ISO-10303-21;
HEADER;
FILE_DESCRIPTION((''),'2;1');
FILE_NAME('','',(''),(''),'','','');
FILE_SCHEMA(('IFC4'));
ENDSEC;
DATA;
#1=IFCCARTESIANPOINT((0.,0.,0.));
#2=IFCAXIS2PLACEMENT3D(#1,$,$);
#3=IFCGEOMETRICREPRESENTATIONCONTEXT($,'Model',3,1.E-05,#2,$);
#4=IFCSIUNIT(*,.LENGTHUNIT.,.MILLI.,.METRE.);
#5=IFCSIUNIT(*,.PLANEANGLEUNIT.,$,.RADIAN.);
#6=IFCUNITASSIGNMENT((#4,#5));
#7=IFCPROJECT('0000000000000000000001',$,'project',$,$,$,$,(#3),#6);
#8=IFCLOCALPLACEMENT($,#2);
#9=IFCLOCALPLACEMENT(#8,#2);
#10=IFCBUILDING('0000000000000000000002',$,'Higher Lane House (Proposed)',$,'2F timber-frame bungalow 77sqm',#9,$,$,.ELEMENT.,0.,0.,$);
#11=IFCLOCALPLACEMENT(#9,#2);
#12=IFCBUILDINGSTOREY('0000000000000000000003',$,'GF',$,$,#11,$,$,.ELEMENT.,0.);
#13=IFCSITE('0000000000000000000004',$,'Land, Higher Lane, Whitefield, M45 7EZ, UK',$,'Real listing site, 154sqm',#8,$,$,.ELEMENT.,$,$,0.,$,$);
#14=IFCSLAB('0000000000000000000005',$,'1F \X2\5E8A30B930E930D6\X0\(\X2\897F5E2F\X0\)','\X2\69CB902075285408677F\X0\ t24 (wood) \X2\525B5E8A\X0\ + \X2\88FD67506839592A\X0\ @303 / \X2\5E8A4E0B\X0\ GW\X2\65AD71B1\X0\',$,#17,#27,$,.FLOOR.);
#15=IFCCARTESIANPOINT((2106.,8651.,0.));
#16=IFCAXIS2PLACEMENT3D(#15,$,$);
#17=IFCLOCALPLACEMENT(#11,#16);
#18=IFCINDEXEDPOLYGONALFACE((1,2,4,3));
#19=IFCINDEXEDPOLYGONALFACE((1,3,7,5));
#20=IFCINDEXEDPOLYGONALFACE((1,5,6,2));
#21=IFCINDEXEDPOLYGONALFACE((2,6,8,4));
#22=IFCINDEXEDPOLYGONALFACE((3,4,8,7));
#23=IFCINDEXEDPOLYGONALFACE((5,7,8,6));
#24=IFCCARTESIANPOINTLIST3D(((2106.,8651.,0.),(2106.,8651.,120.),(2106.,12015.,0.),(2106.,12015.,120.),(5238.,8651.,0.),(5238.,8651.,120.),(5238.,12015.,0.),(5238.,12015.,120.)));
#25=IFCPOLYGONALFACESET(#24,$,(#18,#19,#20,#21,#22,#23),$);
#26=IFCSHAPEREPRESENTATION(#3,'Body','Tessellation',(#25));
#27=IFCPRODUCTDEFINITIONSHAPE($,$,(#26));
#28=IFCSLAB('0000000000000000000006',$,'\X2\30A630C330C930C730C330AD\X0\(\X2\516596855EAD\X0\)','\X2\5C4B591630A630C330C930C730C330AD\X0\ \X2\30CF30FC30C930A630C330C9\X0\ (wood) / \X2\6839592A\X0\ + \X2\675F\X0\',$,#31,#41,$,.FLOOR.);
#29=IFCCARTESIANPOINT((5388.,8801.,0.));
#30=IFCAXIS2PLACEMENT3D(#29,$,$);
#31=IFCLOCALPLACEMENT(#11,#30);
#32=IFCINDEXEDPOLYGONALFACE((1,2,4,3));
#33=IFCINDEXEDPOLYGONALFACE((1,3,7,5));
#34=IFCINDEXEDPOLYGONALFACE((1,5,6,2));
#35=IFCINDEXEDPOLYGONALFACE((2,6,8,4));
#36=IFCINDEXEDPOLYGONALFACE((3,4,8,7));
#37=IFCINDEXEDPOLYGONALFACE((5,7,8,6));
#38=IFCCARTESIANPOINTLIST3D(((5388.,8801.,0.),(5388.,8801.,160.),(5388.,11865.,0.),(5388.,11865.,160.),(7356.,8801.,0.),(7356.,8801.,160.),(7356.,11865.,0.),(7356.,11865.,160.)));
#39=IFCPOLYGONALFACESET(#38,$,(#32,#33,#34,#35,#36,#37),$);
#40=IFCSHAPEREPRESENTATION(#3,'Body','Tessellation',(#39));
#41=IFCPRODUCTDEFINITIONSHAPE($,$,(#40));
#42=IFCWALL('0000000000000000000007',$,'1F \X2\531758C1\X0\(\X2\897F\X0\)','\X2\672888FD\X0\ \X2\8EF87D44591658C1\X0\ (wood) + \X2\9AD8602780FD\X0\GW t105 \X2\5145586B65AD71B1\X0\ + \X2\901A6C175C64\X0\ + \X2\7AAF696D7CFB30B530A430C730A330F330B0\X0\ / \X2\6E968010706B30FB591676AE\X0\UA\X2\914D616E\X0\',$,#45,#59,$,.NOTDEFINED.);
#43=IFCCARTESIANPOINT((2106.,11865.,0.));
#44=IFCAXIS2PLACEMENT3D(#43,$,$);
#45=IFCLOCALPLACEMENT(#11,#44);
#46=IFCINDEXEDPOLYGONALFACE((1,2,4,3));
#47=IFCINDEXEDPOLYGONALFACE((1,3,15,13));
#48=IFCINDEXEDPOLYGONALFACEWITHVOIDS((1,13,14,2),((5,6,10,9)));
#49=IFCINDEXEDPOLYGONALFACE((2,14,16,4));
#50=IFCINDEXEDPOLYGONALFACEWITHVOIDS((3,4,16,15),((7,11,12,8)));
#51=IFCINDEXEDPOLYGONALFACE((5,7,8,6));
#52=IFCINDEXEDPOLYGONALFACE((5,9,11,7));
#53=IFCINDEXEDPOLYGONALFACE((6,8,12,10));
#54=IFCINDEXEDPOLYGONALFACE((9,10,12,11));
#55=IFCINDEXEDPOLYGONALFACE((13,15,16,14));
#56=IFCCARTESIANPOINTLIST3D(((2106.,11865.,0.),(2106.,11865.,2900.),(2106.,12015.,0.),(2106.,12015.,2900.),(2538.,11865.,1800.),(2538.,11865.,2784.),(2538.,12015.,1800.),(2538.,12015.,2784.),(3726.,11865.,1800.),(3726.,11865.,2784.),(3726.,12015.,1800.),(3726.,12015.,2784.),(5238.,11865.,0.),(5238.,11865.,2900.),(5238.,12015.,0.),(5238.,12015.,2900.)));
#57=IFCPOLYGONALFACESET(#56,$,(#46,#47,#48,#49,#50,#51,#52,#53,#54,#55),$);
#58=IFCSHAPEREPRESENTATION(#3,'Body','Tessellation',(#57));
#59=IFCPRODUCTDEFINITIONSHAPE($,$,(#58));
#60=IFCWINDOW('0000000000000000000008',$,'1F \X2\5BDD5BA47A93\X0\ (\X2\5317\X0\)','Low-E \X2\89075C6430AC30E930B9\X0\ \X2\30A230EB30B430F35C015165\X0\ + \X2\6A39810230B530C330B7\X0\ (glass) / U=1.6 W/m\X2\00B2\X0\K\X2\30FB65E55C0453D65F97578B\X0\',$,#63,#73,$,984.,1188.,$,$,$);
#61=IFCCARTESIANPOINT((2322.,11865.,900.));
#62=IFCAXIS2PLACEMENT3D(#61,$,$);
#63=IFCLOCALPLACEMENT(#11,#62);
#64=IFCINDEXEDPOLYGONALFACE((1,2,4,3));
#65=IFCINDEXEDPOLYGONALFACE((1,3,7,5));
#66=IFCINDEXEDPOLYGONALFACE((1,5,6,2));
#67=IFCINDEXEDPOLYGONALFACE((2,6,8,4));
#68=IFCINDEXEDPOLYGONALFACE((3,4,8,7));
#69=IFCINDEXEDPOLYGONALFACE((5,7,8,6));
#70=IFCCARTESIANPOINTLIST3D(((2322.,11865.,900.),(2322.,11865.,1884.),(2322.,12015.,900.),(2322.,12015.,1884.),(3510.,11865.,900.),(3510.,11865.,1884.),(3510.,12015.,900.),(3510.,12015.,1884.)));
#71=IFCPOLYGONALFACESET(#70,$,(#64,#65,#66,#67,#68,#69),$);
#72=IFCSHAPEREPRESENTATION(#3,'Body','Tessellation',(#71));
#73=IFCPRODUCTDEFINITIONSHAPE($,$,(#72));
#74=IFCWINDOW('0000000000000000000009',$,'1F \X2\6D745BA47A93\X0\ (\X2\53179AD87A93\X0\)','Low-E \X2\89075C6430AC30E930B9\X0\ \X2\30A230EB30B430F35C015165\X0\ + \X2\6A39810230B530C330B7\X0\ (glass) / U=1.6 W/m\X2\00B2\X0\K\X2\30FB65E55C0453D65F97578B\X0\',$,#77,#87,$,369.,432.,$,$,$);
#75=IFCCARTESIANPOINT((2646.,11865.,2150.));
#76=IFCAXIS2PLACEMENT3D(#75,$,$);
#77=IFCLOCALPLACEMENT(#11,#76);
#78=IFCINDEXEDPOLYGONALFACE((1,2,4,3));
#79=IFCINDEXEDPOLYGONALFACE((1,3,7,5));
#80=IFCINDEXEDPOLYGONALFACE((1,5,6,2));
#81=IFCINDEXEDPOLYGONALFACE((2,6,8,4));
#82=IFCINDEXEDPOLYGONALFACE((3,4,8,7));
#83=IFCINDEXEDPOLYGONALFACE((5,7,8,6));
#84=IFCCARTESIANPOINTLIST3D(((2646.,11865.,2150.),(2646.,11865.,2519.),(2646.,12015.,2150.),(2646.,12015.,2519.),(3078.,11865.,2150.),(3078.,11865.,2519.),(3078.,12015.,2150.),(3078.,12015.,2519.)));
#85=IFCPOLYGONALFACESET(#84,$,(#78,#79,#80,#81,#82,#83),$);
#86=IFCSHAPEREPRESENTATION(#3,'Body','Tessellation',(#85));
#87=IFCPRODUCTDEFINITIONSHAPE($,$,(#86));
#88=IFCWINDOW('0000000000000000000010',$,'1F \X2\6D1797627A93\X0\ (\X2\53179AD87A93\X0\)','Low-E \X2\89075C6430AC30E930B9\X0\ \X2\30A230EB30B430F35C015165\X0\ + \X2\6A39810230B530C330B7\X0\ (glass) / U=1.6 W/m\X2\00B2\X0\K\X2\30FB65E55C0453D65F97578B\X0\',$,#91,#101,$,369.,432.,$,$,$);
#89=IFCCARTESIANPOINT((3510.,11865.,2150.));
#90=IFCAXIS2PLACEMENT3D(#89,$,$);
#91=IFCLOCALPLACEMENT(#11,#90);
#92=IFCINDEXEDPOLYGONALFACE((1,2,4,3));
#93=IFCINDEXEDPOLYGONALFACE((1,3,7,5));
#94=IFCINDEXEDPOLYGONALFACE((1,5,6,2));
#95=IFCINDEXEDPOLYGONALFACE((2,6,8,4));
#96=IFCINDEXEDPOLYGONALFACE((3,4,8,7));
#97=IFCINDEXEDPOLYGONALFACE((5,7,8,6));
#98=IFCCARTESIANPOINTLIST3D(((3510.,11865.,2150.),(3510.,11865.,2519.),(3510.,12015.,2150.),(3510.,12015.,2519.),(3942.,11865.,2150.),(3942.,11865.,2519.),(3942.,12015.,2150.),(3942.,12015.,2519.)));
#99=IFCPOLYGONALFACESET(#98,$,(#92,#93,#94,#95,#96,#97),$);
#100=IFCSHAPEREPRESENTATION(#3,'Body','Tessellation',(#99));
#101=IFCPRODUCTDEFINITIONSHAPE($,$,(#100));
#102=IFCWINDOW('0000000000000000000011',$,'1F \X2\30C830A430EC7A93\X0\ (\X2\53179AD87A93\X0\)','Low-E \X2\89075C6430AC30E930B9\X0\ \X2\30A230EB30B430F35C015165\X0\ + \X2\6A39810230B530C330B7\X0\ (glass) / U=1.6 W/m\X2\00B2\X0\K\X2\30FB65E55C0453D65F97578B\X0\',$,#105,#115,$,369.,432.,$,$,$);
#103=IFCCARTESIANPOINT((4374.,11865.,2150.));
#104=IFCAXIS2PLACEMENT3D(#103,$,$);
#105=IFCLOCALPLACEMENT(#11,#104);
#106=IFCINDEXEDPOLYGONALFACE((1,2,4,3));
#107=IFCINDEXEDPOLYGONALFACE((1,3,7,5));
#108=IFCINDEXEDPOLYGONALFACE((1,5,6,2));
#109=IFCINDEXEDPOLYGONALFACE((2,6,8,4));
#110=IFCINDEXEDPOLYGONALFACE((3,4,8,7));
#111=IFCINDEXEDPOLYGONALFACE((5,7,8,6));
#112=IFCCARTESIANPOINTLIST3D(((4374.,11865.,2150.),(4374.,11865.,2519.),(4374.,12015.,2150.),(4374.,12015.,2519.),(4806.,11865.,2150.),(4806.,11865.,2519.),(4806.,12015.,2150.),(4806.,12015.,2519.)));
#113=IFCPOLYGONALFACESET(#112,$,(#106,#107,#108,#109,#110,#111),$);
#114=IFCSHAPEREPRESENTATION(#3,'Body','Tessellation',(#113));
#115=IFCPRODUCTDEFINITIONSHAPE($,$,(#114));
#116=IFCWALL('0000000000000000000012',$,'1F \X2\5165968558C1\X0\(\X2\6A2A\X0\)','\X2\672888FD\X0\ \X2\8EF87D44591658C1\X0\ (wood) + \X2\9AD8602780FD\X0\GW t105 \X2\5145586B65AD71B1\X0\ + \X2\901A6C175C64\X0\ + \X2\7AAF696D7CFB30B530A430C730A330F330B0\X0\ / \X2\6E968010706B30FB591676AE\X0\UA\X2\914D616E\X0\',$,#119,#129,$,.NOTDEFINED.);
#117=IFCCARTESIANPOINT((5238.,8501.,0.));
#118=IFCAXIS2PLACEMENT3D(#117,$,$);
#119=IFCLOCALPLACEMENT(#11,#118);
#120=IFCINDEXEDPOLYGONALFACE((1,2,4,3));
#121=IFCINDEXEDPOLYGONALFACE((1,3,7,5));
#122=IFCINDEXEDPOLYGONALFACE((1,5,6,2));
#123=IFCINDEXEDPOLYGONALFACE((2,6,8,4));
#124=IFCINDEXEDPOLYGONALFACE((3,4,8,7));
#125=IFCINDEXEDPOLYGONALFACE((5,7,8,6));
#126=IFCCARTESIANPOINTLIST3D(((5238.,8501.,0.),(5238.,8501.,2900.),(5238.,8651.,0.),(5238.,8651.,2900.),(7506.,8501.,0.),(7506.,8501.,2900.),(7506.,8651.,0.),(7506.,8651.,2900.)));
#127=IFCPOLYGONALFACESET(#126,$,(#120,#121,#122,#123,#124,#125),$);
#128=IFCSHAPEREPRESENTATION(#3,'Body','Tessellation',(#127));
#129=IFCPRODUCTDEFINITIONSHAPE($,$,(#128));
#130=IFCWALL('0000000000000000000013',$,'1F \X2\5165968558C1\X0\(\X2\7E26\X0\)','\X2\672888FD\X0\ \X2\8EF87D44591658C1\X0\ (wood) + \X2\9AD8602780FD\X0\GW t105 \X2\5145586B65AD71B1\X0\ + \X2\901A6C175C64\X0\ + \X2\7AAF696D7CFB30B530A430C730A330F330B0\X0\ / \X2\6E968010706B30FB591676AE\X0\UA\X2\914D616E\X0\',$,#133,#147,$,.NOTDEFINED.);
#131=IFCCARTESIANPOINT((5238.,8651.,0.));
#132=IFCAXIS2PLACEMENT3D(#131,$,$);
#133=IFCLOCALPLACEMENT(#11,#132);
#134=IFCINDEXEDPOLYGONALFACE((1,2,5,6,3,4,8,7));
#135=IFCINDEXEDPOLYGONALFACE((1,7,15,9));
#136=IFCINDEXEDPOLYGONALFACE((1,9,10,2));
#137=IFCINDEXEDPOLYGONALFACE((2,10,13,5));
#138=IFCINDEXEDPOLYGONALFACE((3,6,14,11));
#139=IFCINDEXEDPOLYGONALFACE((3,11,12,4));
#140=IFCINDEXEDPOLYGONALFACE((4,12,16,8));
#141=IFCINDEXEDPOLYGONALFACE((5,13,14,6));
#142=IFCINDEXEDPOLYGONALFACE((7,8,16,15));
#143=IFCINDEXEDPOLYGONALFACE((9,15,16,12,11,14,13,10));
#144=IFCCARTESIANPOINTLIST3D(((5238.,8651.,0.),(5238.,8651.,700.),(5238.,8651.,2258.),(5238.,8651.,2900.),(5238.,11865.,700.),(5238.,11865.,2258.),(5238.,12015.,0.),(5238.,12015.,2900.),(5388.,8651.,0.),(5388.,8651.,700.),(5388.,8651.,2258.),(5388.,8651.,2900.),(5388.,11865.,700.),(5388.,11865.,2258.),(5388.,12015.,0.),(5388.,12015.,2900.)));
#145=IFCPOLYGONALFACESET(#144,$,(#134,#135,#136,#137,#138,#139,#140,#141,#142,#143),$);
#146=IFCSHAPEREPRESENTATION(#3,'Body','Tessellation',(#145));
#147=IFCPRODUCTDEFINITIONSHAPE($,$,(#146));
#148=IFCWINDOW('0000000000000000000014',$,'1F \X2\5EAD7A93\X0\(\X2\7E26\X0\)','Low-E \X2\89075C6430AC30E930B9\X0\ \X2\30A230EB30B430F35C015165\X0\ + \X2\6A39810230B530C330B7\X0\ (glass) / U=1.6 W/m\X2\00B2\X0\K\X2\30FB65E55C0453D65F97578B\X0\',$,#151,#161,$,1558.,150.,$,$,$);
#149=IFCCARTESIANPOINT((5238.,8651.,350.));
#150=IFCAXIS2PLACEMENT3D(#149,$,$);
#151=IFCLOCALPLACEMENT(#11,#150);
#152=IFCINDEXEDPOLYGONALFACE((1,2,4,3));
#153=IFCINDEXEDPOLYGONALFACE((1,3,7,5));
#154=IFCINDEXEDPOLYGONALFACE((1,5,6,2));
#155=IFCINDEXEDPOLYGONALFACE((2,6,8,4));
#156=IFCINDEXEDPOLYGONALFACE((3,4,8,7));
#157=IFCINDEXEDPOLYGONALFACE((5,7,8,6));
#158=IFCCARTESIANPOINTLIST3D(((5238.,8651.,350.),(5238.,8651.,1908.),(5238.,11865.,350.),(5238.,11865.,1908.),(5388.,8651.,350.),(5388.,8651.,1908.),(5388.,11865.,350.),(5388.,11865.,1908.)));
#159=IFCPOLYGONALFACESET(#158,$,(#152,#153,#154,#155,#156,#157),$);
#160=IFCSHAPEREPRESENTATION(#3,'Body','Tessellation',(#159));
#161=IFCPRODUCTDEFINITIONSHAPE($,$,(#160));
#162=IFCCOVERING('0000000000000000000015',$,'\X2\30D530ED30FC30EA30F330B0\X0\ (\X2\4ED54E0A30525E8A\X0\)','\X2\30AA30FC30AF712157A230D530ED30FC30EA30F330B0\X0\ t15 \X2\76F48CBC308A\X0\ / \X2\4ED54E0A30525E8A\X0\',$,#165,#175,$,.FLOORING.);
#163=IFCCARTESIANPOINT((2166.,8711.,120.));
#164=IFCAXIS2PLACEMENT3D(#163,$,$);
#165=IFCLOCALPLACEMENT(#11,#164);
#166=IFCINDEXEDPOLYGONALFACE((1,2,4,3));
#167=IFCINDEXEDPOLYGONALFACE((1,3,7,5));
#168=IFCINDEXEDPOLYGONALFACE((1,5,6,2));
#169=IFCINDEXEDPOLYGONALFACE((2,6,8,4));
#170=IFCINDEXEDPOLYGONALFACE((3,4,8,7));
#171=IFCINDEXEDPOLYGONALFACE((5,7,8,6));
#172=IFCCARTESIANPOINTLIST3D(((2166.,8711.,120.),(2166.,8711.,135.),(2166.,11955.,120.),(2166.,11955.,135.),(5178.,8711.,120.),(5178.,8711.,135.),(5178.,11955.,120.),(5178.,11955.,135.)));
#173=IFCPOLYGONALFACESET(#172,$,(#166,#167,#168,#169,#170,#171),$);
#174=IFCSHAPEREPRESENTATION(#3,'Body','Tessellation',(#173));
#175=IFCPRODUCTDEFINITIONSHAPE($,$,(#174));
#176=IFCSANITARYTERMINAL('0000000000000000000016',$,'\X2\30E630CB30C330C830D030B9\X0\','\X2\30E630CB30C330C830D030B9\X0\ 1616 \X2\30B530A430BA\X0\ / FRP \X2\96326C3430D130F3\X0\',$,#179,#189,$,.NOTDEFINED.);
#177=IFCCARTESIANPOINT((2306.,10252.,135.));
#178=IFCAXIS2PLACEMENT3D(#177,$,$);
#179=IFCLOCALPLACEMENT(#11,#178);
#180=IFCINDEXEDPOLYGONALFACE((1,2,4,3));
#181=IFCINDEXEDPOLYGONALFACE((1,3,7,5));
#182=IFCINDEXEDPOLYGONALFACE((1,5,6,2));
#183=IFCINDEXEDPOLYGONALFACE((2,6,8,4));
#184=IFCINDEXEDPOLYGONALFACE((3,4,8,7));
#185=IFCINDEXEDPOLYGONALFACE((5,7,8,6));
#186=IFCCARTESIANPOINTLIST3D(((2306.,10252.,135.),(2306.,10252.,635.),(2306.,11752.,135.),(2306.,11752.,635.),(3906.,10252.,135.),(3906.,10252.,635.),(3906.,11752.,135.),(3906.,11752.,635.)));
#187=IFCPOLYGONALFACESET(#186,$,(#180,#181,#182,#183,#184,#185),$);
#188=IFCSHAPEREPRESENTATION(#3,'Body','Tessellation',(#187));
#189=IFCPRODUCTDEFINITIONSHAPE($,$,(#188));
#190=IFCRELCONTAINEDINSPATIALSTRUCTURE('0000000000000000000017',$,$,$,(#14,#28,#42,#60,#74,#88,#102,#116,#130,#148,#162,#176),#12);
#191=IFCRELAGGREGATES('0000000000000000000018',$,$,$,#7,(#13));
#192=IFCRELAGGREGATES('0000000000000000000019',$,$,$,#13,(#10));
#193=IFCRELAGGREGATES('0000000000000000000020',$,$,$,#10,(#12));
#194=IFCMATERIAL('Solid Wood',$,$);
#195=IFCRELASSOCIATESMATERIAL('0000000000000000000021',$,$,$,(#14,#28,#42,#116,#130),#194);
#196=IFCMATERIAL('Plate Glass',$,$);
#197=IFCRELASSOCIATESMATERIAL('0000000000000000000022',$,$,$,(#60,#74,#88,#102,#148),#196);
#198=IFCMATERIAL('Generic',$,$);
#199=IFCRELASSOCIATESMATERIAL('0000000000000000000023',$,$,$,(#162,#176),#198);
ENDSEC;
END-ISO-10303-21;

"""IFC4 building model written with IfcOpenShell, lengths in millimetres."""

from ifc_helpers import new_model, si_unit, frame, frame_2d, origin, place, context, project, spatial, rectangle, extrude, material, element, fill, save


model = new_model("IFC4")

# Units and contexts
model_context = context("Model", 3, precision=1e-05, world=origin())
ifc_project = project(units=[si_unit("LENGTHUNIT", "METRE", prefix="MILLI"), si_unit("PLANEANGLEUNIT", "RADIAN")], contexts=[model_context])

# Site, building, storey
site_placement = place(None, origin())
site = spatial("IfcSite", under=ifc_project, at=site_placement, Name="Land, Higher Lane, Whitefield, M45 7EZ, UK", ObjectType="Real listing site, 154sqm", CompositionType="ELEMENT", RefElevation=0.0)
building_placement = place(site_placement, origin())
building = spatial("IfcBuilding", under=site, at=building_placement, Name="Higher Lane House (Proposed)", ObjectType="2F timber-frame bungalow 77sqm", CompositionType="ELEMENT", ElevationOfRefHeight=0.0, ElevationOfTerrain=0.0)
storey_placement = place(building_placement, origin())
storey = spatial("IfcBuildingStorey", under=building, at=storey_placement, Name="GF", CompositionType="ELEMENT", Elevation=0.0)

# Slabs
ifc_material_1 = material(Name="Solid Wood")
slab_1_placement = place(storey_placement, frame((2106.0, 8651.0, 0.0)))
element("IfcSlab", 1, at=slab_1_placement, inside=storey, material=ifc_material_1, Name="1F 床スラブ(西帯)", Description="構造用合板 t24 (wood) 剛床 + 製材根太 @303 / 床下 GW断熱", PredefinedType="FLOOR", context=model_context, shape_type="SweptSolid", body=[
    extrude(rectangle(XDim=3132.0, YDim=3364.0, at=frame_2d((1566.0, 1682.0))), frame((2106.0, 8651.0, 0.0)), (0.0, 0.0, 1.0), 120.0),
])
slab_2_placement = place(storey_placement, frame((5388.0, 8801.0, 0.0)))
element("IfcSlab", 2, at=slab_2_placement, inside=storey, material=ifc_material_1, Name="ウッドデッキ(入隅庭)", Description="屋外ウッドデッキ ハードウッド (wood) / 根太 + 束", PredefinedType="FLOOR", context=model_context, shape_type="SweptSolid", body=[
    extrude(rectangle(XDim=1968.0, YDim=3064.0, at=frame_2d((984.0, 1532.0))), frame((5388.0, 8801.0, 0.0)), (0.0, 0.0, 1.0), 160.0),
])

# Wall, openings, windows
wall_1_placement = place(storey_placement, frame((2106.0, 11865.0, 0.0)))
wall_1 = element("IfcWall", 3, at=wall_1_placement, inside=storey, material=ifc_material_1, Name="1F 北壁(西)", Description="木製 軸組外壁 (wood) + 高性能GW t105 充填断熱 + 通気層 + 窯業系サイディング / 準耐火・外皮UA配慮", PredefinedType="NOTDEFINED", context=model_context, shape_type="SweptSolid", body=[
    extrude(rectangle(XDim=3132.0, YDim=150.0, at=frame_2d((1566.0, 75.0))), frame((2106.0, 11865.0, 0.0)), (0.0, 0.0, 1.0), 2900.0),
])
opening_1_placement = place(storey_placement, frame((2322.0, 11865.0, 900.0)))
opening_1 = element("IfcOpeningElement", 4, at=opening_1_placement, cuts=wall_1, PredefinedType="NOTDEFINED", context=model_context, shape_type="SweptSolid", body=[
    extrude(rectangle(XDim=1188.0, YDim=150.0, at=frame_2d((594.0, 75.0))), frame((2322.0, 11865.0, 900.0)), (0.0, 0.0, 1.0), 984.0),
])
opening_2_placement = place(storey_placement, frame((2646.0, 11865.0, 2150.0)))
opening_2 = element("IfcOpeningElement", 5, at=opening_2_placement, cuts=wall_1, PredefinedType="NOTDEFINED", context=model_context, shape_type="SweptSolid", body=[
    extrude(rectangle(XDim=432.0, YDim=150.0, at=frame_2d((216.0, 75.0))), frame((2646.0, 11865.0, 2150.0)), (0.0, 0.0, 1.0), 369.0),
])
opening_3_placement = place(storey_placement, frame((3510.0, 11865.0, 2150.0)))
opening_3 = element("IfcOpeningElement", 6, at=opening_3_placement, cuts=wall_1, PredefinedType="NOTDEFINED", context=model_context, shape_type="SweptSolid", body=[
    extrude(rectangle(XDim=432.0, YDim=150.0, at=frame_2d((216.0, 75.0))), frame((3510.0, 11865.0, 2150.0)), (0.0, 0.0, 1.0), 369.0),
])
opening_4_placement = place(storey_placement, frame((4374.0, 11865.0, 2150.0)))
opening_4 = element("IfcOpeningElement", 7, at=opening_4_placement, cuts=wall_1, PredefinedType="NOTDEFINED", context=model_context, shape_type="SweptSolid", body=[
    extrude(rectangle(XDim=432.0, YDim=150.0, at=frame_2d((216.0, 75.0))), frame((4374.0, 11865.0, 2150.0)), (0.0, 0.0, 1.0), 369.0),
])
ifc_material_2 = material(Name="Plate Glass")
window_1_placement = place(storey_placement, frame((2322.0, 11865.0, 900.0)))
window_1 = element("IfcWindow", 8, at=window_1_placement, inside=storey, material=ifc_material_2, Name="1F 寝室窓 (北)", Description="Low-E 複層ガラス アルゴン封入 + 樹脂サッシ (glass) / U=1.6 W/m²K・日射取得型", OverallHeight=984.0, OverallWidth=1188.0, context=model_context, shape_type="SweptSolid", body=[
    extrude(rectangle(XDim=1188.0, YDim=150.0, at=frame_2d((594.0, 75.0))), frame((2322.0, 11865.0, 900.0)), (0.0, 0.0, 1.0), 984.0),
])
fill(opening_1, window_1)
window_2_placement = place(storey_placement, frame((2646.0, 11865.0, 2150.0)))
window_2 = element("IfcWindow", 9, at=window_2_placement, inside=storey, material=ifc_material_2, Name="1F 浴室窓 (北高窓)", Description="Low-E 複層ガラス アルゴン封入 + 樹脂サッシ (glass) / U=1.6 W/m²K・日射取得型", OverallHeight=369.0, OverallWidth=432.0, context=model_context, shape_type="SweptSolid", body=[
    extrude(rectangle(XDim=432.0, YDim=150.0, at=frame_2d((216.0, 75.0))), frame((2646.0, 11865.0, 2150.0)), (0.0, 0.0, 1.0), 369.0),
])
fill(opening_2, window_2)
window_3_placement = place(storey_placement, frame((3510.0, 11865.0, 2150.0)))
window_3 = element("IfcWindow", 10, at=window_3_placement, inside=storey, material=ifc_material_2, Name="1F 洗面窓 (北高窓)", Description="Low-E 複層ガラス アルゴン封入 + 樹脂サッシ (glass) / U=1.6 W/m²K・日射取得型", OverallHeight=369.0, OverallWidth=432.0, context=model_context, shape_type="SweptSolid", body=[
    extrude(rectangle(XDim=432.0, YDim=150.0, at=frame_2d((216.0, 75.0))), frame((3510.0, 11865.0, 2150.0)), (0.0, 0.0, 1.0), 369.0),
])
fill(opening_3, window_3)
window_4_placement = place(storey_placement, frame((4374.0, 11865.0, 2150.0)))
window_4 = element("IfcWindow", 11, at=window_4_placement, inside=storey, material=ifc_material_2, Name="1F トイレ窓 (北高窓)", Description="Low-E 複層ガラス アルゴン封入 + 樹脂サッシ (glass) / U=1.6 W/m²K・日射取得型", OverallHeight=369.0, OverallWidth=432.0, context=model_context, shape_type="SweptSolid", body=[
    extrude(rectangle(XDim=432.0, YDim=150.0, at=frame_2d((216.0, 75.0))), frame((4374.0, 11865.0, 2150.0)), (0.0, 0.0, 1.0), 369.0),
])
fill(opening_4, window_4)

# Wall
wall_2_placement = place(storey_placement, frame((5238.0, 8501.0, 0.0)))
element("IfcWall", 12, at=wall_2_placement, inside=storey, material=ifc_material_1, Name="1F 入隅壁(横)", Description="木製 軸組外壁 (wood) + 高性能GW t105 充填断熱 + 通気層 + 窯業系サイディング / 準耐火・外皮UA配慮", PredefinedType="NOTDEFINED", context=model_context, shape_type="SweptSolid", body=[
    extrude(rectangle(XDim=2268.0, YDim=150.0, at=frame_2d((1134.0, 75.0))), frame((5238.0, 8501.0, 0.0)), (0.0, 0.0, 1.0), 2900.0),
])

# Wall, opening, window
wall_3_placement = place(storey_placement, frame((5238.0, 8651.0, 0.0)))
wall_3 = element("IfcWall", 13, at=wall_3_placement, inside=storey, material=ifc_material_1, Name="1F 入隅壁(縦)", Description="木製 軸組外壁 (wood) + 高性能GW t105 充填断熱 + 通気層 + 窯業系サイディング / 準耐火・外皮UA配慮", PredefinedType="NOTDEFINED", context=model_context, shape_type="SweptSolid", body=[
    extrude(rectangle(XDim=150.0, YDim=3364.0, at=frame_2d((75.0, 1682.0))), frame((5238.0, 8651.0, 0.0)), (0.0, 0.0, 1.0), 2900.0),
])
opening_5_placement = place(storey_placement, frame((5238.0, 8651.0, 350.0)))
opening_5 = element("IfcOpeningElement", 14, at=opening_5_placement, cuts=wall_3, PredefinedType="NOTDEFINED", context=model_context, shape_type="SweptSolid", body=[
    extrude(rectangle(XDim=150.0, YDim=3214.0, at=frame_2d((75.0, 1607.0))), frame((5238.0, 8651.0, 350.0)), (0.0, 0.0, 1.0), 1558.0),
])
window_5_placement = place(storey_placement, frame((5238.0, 8651.0, 350.0)))
window_5 = element("IfcWindow", 15, at=window_5_placement, inside=storey, material=ifc_material_2, Name="1F 庭窓(縦)", Description="Low-E 複層ガラス アルゴン封入 + 樹脂サッシ (glass) / U=1.6 W/m²K・日射取得型", OverallHeight=1558.0, OverallWidth=150.0, context=model_context, shape_type="SweptSolid", body=[
    extrude(rectangle(XDim=150.0, YDim=3214.0, at=frame_2d((75.0, 1607.0))), frame((5238.0, 8651.0, 350.0)), (0.0, 0.0, 1.0), 1558.0),
])
fill(opening_5, window_5)

# Covering
ifc_material_3 = material(Name="Generic")
covering_placement = place(storey_placement, frame((2166.0, 8711.0, 120.0)))
element("IfcCovering", 16, at=covering_placement, inside=storey, material=ifc_material_3, Name="フローリング (仕上げ床)", Description="オーク無垢フローリング t15 直貼り / 仕上げ床", PredefinedType="FLOORING", context=model_context, shape_type="SweptSolid", body=[
    extrude(rectangle(XDim=3012.0, YDim=3244.0, at=frame_2d((1506.0, 1622.0))), frame((2166.0, 8711.0, 120.0)), (0.0, 0.0, 1.0), 15.0),
])

# Sanitary terminal
sanitary_terminal_1_placement = place(storey_placement, frame((2306.0, 10252.0, 135.0)))
element("IfcSanitaryTerminal", 17, at=sanitary_terminal_1_placement, inside=storey, material=ifc_material_3, Name="ユニットバス", Description="ユニットバス 1616 サイズ / FRP 防水パン", PredefinedType="NOTDEFINED", context=model_context, shape_type="SweptSolid", body=[
    extrude(rectangle(XDim=1600.0, YDim=1500.0, at=frame_2d((800.0, 750.0))), frame((2306.0, 10252.0, 135.0)), (0.0, 0.0, 1.0), 500.0),
])

save(model, "model.ifc")
